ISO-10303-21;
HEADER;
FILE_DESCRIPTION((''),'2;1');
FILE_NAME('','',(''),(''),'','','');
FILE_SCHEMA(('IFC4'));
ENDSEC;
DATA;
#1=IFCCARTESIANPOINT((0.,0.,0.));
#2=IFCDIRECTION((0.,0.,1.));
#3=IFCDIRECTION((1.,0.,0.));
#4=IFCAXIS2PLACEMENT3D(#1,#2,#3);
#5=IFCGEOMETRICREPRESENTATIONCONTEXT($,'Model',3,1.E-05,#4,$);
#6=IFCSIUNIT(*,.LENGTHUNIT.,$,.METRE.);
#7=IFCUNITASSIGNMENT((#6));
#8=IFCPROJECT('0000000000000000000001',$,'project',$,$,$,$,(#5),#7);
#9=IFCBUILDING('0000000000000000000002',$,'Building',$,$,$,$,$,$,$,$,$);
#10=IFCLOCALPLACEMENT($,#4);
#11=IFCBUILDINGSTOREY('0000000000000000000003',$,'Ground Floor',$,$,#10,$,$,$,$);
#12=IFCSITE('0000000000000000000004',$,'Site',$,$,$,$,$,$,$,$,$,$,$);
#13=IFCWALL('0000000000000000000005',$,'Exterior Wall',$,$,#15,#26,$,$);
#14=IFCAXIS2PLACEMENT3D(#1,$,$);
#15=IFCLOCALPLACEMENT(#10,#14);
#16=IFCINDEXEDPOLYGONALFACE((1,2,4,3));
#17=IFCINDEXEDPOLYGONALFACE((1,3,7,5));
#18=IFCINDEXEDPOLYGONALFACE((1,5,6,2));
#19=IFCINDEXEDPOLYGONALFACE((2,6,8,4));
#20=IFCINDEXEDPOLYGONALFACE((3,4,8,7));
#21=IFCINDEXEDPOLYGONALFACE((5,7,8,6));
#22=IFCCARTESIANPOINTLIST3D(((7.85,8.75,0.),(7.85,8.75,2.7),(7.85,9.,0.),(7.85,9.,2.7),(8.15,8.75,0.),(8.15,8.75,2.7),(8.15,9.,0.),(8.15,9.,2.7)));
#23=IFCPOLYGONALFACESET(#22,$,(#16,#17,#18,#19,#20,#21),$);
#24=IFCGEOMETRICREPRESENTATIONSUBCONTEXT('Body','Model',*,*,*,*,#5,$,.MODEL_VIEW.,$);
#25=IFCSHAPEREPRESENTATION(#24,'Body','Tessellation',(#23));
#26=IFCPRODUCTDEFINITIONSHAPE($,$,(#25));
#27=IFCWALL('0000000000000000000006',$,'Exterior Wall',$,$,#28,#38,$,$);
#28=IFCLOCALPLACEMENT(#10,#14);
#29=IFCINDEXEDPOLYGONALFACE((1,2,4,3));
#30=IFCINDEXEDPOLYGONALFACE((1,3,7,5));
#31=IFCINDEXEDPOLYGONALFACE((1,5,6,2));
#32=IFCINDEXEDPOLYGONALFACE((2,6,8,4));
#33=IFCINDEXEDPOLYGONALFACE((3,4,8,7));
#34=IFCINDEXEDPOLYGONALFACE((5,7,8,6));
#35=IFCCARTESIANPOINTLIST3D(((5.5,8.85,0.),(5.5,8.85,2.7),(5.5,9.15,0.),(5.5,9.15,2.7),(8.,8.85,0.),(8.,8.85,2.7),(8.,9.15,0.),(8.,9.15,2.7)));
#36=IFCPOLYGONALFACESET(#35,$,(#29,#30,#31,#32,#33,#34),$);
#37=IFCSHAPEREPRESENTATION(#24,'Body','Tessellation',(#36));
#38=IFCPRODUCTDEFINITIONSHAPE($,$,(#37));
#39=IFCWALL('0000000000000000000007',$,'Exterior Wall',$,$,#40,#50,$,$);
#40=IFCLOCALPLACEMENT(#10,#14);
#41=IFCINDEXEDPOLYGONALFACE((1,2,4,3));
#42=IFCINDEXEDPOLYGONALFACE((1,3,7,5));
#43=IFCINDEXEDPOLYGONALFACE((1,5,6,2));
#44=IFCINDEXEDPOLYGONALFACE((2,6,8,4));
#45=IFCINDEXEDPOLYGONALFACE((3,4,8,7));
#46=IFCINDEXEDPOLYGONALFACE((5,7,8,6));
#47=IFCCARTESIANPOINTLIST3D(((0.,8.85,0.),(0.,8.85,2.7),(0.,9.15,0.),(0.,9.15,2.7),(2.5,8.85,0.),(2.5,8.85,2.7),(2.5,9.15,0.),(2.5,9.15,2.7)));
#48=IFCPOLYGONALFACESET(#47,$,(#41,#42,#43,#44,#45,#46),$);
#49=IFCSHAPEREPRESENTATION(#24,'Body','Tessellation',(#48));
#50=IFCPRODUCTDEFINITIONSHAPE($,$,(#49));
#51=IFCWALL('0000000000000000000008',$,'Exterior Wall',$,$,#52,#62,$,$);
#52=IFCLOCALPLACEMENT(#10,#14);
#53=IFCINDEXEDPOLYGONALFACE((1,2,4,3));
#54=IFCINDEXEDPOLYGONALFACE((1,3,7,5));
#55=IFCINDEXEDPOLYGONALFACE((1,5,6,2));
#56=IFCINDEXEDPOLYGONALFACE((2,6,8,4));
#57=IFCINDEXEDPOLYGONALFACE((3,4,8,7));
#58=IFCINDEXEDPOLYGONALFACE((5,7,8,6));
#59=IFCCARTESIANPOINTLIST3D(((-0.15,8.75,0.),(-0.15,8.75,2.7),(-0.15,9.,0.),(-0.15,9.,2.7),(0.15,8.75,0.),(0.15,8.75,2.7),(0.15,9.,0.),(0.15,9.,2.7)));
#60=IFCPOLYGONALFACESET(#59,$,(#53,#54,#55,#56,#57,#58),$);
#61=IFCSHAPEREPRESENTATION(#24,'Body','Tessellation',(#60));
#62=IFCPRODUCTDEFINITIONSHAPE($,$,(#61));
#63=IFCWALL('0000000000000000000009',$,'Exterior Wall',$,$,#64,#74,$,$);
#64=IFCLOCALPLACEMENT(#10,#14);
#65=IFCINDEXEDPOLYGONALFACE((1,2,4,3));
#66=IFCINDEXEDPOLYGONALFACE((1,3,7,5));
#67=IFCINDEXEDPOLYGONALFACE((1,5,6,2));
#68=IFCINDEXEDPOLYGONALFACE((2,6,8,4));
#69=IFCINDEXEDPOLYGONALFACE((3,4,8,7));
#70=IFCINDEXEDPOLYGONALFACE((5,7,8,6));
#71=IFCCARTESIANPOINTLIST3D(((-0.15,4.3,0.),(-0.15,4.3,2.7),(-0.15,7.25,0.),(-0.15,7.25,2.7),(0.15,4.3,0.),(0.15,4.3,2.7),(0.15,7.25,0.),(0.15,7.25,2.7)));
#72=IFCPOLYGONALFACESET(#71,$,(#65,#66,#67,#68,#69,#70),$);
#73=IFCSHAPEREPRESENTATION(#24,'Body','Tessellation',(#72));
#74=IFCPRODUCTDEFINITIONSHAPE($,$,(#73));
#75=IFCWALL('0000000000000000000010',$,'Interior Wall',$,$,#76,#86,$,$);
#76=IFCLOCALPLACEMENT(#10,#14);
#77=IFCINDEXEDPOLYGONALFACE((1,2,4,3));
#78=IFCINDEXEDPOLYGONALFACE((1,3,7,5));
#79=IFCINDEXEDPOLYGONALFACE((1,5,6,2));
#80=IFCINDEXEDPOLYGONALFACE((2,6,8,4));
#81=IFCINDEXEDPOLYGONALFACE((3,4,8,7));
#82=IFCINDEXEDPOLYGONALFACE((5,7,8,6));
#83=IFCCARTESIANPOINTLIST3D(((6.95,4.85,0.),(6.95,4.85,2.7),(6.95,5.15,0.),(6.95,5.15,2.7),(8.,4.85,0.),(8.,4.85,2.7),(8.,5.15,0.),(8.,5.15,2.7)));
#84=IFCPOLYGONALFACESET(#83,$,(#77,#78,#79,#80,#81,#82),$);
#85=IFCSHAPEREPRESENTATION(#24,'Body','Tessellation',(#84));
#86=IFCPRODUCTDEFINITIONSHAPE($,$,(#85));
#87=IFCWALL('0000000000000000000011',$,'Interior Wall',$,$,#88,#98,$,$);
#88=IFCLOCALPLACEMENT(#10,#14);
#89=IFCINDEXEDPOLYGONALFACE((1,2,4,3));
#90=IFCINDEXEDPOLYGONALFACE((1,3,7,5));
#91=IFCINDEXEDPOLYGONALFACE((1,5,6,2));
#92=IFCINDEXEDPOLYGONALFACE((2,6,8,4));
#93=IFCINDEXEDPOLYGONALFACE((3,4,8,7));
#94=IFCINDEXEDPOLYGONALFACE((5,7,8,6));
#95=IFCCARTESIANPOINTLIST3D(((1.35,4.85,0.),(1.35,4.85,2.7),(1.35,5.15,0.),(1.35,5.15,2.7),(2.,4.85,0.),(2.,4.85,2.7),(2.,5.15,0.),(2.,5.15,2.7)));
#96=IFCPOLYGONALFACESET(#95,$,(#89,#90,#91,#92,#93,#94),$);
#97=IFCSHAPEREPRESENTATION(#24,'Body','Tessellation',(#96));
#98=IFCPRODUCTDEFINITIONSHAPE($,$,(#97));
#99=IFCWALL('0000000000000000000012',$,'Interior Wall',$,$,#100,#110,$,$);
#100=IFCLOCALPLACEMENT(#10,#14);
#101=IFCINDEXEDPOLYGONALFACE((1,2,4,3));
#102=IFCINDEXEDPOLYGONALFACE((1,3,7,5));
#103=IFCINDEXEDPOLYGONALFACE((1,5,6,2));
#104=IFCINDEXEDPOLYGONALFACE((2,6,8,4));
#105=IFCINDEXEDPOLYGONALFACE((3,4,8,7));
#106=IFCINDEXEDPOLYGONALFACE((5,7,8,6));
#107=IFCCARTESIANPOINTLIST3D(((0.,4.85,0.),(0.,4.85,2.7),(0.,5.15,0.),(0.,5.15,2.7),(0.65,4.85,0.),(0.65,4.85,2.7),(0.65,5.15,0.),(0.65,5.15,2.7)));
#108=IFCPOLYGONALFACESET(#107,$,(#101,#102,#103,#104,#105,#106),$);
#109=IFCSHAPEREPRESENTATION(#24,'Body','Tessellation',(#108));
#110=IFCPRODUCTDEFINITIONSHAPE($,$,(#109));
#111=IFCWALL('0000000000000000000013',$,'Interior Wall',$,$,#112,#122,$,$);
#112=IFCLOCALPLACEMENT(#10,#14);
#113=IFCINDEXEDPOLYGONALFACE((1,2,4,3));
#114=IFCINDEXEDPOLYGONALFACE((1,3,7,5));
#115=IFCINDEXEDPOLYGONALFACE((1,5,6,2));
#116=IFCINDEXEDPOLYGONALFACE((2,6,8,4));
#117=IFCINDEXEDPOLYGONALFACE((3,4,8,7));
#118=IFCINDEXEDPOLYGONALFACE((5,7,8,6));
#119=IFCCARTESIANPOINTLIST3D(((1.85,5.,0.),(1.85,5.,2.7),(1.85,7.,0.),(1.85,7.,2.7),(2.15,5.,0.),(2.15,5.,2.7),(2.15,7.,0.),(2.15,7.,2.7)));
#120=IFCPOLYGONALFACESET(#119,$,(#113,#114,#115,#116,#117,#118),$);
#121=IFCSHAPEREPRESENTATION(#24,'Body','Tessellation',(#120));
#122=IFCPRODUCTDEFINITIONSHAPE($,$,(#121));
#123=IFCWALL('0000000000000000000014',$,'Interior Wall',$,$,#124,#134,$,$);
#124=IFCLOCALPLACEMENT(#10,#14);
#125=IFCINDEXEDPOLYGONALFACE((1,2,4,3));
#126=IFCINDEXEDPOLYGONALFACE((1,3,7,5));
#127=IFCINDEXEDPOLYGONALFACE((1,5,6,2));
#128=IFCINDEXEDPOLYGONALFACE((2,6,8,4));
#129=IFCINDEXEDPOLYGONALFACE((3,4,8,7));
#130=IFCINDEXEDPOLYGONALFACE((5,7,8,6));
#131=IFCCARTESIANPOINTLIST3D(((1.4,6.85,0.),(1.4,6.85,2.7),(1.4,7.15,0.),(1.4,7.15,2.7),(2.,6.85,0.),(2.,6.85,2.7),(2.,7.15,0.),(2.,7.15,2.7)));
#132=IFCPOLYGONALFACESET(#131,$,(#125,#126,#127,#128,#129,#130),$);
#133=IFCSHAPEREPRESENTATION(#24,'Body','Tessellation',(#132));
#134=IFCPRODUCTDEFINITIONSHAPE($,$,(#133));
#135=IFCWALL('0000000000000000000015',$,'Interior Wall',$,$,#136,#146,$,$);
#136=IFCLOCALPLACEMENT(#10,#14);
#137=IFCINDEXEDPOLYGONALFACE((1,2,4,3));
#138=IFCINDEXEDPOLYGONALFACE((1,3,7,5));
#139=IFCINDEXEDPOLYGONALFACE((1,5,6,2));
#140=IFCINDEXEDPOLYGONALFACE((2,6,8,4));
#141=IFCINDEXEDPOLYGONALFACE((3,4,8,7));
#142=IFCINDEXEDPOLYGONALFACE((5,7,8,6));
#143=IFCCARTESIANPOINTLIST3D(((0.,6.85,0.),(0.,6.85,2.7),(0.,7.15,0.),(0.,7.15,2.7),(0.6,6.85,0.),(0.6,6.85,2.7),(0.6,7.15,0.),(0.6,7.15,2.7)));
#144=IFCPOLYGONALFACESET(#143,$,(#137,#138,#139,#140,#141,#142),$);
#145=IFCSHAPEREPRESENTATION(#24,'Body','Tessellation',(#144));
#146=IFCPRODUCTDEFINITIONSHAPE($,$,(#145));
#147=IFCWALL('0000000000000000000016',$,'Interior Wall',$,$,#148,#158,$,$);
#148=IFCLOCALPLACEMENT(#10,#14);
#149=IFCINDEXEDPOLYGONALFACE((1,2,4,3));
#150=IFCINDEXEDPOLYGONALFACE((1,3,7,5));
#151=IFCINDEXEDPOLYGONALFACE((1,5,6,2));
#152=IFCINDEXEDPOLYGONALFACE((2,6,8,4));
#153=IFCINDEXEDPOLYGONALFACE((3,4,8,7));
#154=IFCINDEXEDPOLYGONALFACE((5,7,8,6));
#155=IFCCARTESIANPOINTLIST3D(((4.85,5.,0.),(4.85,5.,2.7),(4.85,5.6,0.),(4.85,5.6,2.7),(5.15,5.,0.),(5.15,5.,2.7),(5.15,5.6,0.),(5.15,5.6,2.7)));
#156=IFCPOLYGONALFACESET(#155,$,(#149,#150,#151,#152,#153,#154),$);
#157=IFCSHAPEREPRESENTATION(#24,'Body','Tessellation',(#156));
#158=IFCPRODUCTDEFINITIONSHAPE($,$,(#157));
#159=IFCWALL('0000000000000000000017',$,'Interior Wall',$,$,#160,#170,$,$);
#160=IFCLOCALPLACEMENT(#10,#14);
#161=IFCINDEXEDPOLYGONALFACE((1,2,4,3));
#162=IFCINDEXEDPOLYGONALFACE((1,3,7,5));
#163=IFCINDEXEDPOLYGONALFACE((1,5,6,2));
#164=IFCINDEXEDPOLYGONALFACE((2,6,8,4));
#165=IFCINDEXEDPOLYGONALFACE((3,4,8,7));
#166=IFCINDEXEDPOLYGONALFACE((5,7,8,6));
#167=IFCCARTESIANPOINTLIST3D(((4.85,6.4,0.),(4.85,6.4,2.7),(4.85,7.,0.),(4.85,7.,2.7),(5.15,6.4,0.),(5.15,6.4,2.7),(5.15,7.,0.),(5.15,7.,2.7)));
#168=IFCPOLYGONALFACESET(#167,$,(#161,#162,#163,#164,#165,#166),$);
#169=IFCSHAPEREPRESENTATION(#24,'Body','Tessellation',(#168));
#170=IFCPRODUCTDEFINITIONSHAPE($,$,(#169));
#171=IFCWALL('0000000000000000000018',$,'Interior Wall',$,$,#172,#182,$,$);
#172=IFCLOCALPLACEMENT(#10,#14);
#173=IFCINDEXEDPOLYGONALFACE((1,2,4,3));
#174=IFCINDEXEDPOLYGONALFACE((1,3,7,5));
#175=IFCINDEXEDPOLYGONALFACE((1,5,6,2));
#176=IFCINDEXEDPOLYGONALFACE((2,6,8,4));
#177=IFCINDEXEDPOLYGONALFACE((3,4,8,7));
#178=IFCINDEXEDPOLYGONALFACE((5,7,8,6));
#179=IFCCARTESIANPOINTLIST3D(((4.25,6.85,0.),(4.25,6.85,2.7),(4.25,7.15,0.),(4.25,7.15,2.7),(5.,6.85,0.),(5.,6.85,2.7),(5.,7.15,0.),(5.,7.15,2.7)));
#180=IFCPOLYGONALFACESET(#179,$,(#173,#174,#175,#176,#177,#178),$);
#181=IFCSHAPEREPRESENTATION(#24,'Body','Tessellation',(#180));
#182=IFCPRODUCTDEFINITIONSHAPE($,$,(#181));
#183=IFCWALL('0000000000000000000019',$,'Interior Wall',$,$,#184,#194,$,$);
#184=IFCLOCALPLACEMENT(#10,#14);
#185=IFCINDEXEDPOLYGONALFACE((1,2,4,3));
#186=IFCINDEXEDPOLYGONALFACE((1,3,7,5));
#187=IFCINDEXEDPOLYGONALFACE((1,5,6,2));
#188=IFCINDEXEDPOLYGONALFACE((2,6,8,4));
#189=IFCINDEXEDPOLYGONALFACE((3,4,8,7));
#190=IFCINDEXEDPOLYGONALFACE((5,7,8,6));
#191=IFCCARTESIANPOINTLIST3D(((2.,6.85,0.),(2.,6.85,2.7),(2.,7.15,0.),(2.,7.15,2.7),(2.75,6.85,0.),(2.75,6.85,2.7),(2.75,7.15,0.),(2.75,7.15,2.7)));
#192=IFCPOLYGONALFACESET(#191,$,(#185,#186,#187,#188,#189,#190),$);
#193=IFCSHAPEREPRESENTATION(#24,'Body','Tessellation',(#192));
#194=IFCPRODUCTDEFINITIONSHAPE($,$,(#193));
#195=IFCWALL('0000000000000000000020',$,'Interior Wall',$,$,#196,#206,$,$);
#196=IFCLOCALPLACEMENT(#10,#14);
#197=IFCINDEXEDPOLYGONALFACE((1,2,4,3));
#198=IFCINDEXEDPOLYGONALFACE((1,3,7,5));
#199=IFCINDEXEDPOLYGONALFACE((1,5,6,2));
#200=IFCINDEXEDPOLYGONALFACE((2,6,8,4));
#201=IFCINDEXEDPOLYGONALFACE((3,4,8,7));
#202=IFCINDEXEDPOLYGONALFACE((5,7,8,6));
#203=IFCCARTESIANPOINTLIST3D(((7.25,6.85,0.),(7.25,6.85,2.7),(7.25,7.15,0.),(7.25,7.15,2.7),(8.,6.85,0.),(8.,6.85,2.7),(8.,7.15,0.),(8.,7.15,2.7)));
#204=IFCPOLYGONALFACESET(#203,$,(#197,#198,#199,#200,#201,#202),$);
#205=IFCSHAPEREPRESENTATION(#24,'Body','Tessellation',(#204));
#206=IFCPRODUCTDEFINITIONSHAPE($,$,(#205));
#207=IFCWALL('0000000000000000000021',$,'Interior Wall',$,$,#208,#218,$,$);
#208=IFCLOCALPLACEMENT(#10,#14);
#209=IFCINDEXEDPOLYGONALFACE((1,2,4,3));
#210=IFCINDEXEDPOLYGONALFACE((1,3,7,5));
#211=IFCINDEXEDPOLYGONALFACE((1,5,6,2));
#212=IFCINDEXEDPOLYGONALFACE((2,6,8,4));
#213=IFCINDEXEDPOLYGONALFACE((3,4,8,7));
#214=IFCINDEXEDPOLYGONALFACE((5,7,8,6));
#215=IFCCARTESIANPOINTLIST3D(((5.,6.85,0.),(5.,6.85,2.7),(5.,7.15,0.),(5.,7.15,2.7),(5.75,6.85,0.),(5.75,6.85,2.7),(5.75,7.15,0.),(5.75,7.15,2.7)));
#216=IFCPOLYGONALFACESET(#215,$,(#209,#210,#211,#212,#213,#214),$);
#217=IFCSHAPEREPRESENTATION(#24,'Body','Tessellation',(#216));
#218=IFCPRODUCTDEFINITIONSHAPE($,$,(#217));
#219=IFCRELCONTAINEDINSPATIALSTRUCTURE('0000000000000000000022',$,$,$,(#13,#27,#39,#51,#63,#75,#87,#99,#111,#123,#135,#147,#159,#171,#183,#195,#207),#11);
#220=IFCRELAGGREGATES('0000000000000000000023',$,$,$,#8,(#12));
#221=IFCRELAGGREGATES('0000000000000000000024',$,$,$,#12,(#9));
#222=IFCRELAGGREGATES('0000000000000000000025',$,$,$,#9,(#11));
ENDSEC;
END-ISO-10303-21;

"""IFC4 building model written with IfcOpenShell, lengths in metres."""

from ifc_helpers import new_model, si_unit, frame, origin_with_axes, place, context, subcontext, project, spatial, indexed_curve, outline, extrude, element, save


model = new_model("IFC4")

# Units and contexts
model_context = context("Model", 3, precision=1e-05, world=origin_with_axes())
body_context = subcontext(model_context, "Body", "Model", "MODEL_VIEW")
ifc_project = project(units=[si_unit("LENGTHUNIT", "METRE")], contexts=[model_context])

# Site, building, storey
site = spatial("IfcSite", under=ifc_project, Name="Site")
building = spatial("IfcBuilding", under=site, Name="Building")
storey_placement = place(None, origin_with_axes())
storey = spatial("IfcBuildingStorey", under=building, at=storey_placement, Name="Ground Floor")

# Walls
wall_1_placement = place(storey_placement, frame((8.0, 8.75, 0.0), z_axis=(0.0, 0.0, 1.0), x_axis=(0.0, 1.0, 0.0)))
element("IfcWall", 1, at=wall_1_placement, inside=storey, Name="Exterior Wall", context=body_context, shape_type="SweptSolid", body=[
    extrude(outline(indexed_curve([(0.0, 0.0), (0.0, 0.3), (0.25, 0.3), (0.25, 0.0), (0.0, 0.0)], self_intersect=False)), frame((0.0, -0.15, 0.0), z_axis=(0.0, 0.0, 1.0), x_axis=(1.0, 0.0, 0.0)), (0.0, 0.0, 1.0), 2.7),
])
for number, where, z_axis, x_axis, name in (
    (2, (8.0, 9.0, 0.0), (0.0, 0.0, 1.0), (-1.0, 0.0, 0.0), "Exterior Wall"),
    (3, (2.5, 9.0, 0.0), (0.0, 0.0, 1.0), (-1.0, 0.0, 0.0), "Exterior Wall"),
):
    element("IfcWall", number, at=place(storey_placement, frame(where, z_axis=z_axis, x_axis=x_axis)), inside=storey, Name=name, context=body_context, shape_type="SweptSolid", body=[
        extrude(outline(indexed_curve([(0.0, 0.0), (0.0, 0.3), (2.5, 0.3), (2.5, 0.0), (0.0, 0.0)], self_intersect=False)), frame((0.0, -0.15, 0.0), z_axis=(0.0, 0.0, 1.0), x_axis=(1.0, 0.0, 0.0)), (0.0, 0.0, 1.0), 2.7),
    ])
wall_2_placement = place(storey_placement, frame((0.0, 9.0, 0.0), z_axis=(0.0, 0.0, 1.0), x_axis=(0.0, -1.0, 0.0)))
element("IfcWall", 4, at=wall_2_placement, inside=storey, Name="Exterior Wall", context=body_context, shape_type="SweptSolid", body=[
    extrude(outline(indexed_curve([(0.0, 0.0), (0.0, 0.3), (0.25, 0.3), (0.25, 0.0), (0.0, 0.0)], self_intersect=False)), frame((0.0, -0.15, 0.0), z_axis=(0.0, 0.0, 1.0), x_axis=(1.0, 0.0, 0.0)), (0.0, 0.0, 1.0), 2.7),
])
wall_3_placement = place(storey_placement, frame((0.0, 7.25, 0.0), z_axis=(0.0, 0.0, 1.0), x_axis=(0.0, -1.0, 0.0)))
element("IfcWall", 5, at=wall_3_placement, inside=storey, Name="Exterior Wall", context=body_context, shape_type="SweptSolid", body=[
    extrude(outline(indexed_curve([(0.0, 0.0), (0.0, 0.3), (2.95, 0.3), (2.95, 0.0), (0.0, 0.0)], self_intersect=False)), frame((0.0, -0.15, 0.0), z_axis=(0.0, 0.0, 1.0), x_axis=(1.0, 0.0, 0.0)), (0.0, 0.0, 1.0), 2.7),
])
wall_4_placement = place(storey_placement, frame((8.0, 5.0, 0.0), z_axis=(0.0, 0.0, 1.0), x_axis=(-1.0, 0.0, 0.0)))
element("IfcWall", 6, at=wall_4_placement, inside=storey, Name="Interior Wall", context=body_context, shape_type="SweptSolid", body=[
    extrude(outline(indexed_curve([(0.0, 0.0), (0.0, 0.3), (1.05, 0.3), (1.05, 0.0), (0.0, 0.0)], self_intersect=False)), frame((0.0, -0.15, 0.0), z_axis=(0.0, 0.0, 1.0), x_axis=(1.0, 0.0, 0.0)), (0.0, 0.0, 1.0), 2.7),
])
for number, where, z_axis, x_axis, name in (
    (7, (2.0, 5.0, 0.0), (0.0, 0.0, 1.0), (-1.0, 0.0, 0.0), "Interior Wall"),
    (8, (0.65, 5.0, 0.0), (0.0, 0.0, 1.0), (-1.0, 0.0, 0.0), "Interior Wall"),
):
    element("IfcWall", number, at=place(storey_placement, frame(where, z_axis=z_axis, x_axis=x_axis)), inside=storey, Name=name, context=body_context, shape_type="SweptSolid", body=[
        extrude(outline(indexed_curve([(0.0, 0.0), (0.0, 0.3), (0.65, 0.3), (0.65, 0.0), (0.0, 0.0)], self_intersect=False)), frame((0.0, -0.15, 0.0), z_axis=(0.0, 0.0, 1.0), x_axis=(1.0, 0.0, 0.0)), (0.0, 0.0, 1.0), 2.7),
    ])
wall_5_placement = place(storey_placement, frame((2.0, 5.0, 0.0), z_axis=(0.0, 0.0, 1.0), x_axis=(0.0, 1.0, 0.0)))
element("IfcWall", 9, at=wall_5_placement, inside=storey, Name="Interior Wall", context=body_context, shape_type="SweptSolid", body=[
    extrude(outline(indexed_curve([(0.0, 0.0), (0.0, 0.3), (2.0, 0.3), (2.0, 0.0), (0.0, 0.0)], self_intersect=False)), frame((0.0, -0.15, 0.0), z_axis=(0.0, 0.0, 1.0), x_axis=(1.0, 0.0, 0.0)), (0.0, 0.0, 1.0), 2.7),
])
for number, where, z_axis, x_axis, name in (
    (10, (2.0, 7.0, 0.0), (0.0, 0.0, 1.0), (-1.0, 0.0, 0.0), "Interior Wall"),
    (11, (0.6, 7.0, 0.0), (0.0, 0.0, 1.0), (-1.0, 0.0, 0.0), "Interior Wall"),
):
    element("IfcWall", number, at=place(storey_placement, frame(where, z_axis=z_axis, x_axis=x_axis)), inside=storey, Name=name, context=body_context, shape_type="SweptSolid", body=[
        extrude(outline(indexed_curve([(0.0, 0.0), (0.0, 0.3), (0.6, 0.3), (0.6, 0.0), (0.0, 0.0)], self_intersect=False)), frame((0.0, -0.15, 0.0), z_axis=(0.0, 0.0, 1.0), x_axis=(1.0, 0.0, 0.0)), (0.0, 0.0, 1.0), 2.7),
    ])
for number, where, z_axis, x_axis, name in (
    (12, (5.0, 5.0, 0.0), (0.0, 0.0, 1.0), (0.0, 1.0, 0.0), "Interior Wall"),
    (13, (5.0, 6.4, 0.0), (0.0, 0.0, 1.0), (0.0, 1.0, 0.0), "Interior Wall"),
):
    element("IfcWall", number, at=place(storey_placement, frame(where, z_axis=z_axis, x_axis=x_axis)), inside=storey, Name=name, context=body_context, shape_type="SweptSolid", body=[
        extrude(outline(indexed_curve([(0.0, 0.0), (0.0, 0.3), (0.6, 0.3), (0.6, 0.0), (0.0, 0.0)], self_intersect=False)), frame((0.0, -0.15, 0.0), z_axis=(0.0, 0.0, 1.0), x_axis=(1.0, 0.0, 0.0)), (0.0, 0.0, 1.0), 2.7),
    ])
for number, where, z_axis, x_axis, name in (
    (14, (5.0, 7.0, 0.0), (0.0, 0.0, 1.0), (-1.0, 0.0, 0.0), "Interior Wall"),
    (15, (2.75, 7.0, 0.0), (0.0, 0.0, 1.0), (-1.0, 0.0, 0.0), "Interior Wall"),
    (16, (8.0, 7.0, 0.0), (0.0, 0.0, 1.0), (-1.0, 0.0, 0.0), "Interior Wall"),
    (17, (5.75, 7.0, 0.0), (0.0, 0.0, 1.0), (-1.0, 0.0, 0.0), "Interior Wall"),
):
    element("IfcWall", number, at=place(storey_placement, frame(where, z_axis=z_axis, x_axis=x_axis)), inside=storey, Name=name, context=body_context, shape_type="SweptSolid", body=[
        extrude(outline(indexed_curve([(0.0, 0.0), (0.0, 0.3), (0.75, 0.3), (0.75, 0.0), (0.0, 0.0)], self_intersect=False)), frame((0.0, -0.15, 0.0), z_axis=(0.0, 0.0, 1.0), x_axis=(1.0, 0.0, 0.0)), (0.0, 0.0, 1.0), 2.7),
    ])

save(model, "model.ifc")
